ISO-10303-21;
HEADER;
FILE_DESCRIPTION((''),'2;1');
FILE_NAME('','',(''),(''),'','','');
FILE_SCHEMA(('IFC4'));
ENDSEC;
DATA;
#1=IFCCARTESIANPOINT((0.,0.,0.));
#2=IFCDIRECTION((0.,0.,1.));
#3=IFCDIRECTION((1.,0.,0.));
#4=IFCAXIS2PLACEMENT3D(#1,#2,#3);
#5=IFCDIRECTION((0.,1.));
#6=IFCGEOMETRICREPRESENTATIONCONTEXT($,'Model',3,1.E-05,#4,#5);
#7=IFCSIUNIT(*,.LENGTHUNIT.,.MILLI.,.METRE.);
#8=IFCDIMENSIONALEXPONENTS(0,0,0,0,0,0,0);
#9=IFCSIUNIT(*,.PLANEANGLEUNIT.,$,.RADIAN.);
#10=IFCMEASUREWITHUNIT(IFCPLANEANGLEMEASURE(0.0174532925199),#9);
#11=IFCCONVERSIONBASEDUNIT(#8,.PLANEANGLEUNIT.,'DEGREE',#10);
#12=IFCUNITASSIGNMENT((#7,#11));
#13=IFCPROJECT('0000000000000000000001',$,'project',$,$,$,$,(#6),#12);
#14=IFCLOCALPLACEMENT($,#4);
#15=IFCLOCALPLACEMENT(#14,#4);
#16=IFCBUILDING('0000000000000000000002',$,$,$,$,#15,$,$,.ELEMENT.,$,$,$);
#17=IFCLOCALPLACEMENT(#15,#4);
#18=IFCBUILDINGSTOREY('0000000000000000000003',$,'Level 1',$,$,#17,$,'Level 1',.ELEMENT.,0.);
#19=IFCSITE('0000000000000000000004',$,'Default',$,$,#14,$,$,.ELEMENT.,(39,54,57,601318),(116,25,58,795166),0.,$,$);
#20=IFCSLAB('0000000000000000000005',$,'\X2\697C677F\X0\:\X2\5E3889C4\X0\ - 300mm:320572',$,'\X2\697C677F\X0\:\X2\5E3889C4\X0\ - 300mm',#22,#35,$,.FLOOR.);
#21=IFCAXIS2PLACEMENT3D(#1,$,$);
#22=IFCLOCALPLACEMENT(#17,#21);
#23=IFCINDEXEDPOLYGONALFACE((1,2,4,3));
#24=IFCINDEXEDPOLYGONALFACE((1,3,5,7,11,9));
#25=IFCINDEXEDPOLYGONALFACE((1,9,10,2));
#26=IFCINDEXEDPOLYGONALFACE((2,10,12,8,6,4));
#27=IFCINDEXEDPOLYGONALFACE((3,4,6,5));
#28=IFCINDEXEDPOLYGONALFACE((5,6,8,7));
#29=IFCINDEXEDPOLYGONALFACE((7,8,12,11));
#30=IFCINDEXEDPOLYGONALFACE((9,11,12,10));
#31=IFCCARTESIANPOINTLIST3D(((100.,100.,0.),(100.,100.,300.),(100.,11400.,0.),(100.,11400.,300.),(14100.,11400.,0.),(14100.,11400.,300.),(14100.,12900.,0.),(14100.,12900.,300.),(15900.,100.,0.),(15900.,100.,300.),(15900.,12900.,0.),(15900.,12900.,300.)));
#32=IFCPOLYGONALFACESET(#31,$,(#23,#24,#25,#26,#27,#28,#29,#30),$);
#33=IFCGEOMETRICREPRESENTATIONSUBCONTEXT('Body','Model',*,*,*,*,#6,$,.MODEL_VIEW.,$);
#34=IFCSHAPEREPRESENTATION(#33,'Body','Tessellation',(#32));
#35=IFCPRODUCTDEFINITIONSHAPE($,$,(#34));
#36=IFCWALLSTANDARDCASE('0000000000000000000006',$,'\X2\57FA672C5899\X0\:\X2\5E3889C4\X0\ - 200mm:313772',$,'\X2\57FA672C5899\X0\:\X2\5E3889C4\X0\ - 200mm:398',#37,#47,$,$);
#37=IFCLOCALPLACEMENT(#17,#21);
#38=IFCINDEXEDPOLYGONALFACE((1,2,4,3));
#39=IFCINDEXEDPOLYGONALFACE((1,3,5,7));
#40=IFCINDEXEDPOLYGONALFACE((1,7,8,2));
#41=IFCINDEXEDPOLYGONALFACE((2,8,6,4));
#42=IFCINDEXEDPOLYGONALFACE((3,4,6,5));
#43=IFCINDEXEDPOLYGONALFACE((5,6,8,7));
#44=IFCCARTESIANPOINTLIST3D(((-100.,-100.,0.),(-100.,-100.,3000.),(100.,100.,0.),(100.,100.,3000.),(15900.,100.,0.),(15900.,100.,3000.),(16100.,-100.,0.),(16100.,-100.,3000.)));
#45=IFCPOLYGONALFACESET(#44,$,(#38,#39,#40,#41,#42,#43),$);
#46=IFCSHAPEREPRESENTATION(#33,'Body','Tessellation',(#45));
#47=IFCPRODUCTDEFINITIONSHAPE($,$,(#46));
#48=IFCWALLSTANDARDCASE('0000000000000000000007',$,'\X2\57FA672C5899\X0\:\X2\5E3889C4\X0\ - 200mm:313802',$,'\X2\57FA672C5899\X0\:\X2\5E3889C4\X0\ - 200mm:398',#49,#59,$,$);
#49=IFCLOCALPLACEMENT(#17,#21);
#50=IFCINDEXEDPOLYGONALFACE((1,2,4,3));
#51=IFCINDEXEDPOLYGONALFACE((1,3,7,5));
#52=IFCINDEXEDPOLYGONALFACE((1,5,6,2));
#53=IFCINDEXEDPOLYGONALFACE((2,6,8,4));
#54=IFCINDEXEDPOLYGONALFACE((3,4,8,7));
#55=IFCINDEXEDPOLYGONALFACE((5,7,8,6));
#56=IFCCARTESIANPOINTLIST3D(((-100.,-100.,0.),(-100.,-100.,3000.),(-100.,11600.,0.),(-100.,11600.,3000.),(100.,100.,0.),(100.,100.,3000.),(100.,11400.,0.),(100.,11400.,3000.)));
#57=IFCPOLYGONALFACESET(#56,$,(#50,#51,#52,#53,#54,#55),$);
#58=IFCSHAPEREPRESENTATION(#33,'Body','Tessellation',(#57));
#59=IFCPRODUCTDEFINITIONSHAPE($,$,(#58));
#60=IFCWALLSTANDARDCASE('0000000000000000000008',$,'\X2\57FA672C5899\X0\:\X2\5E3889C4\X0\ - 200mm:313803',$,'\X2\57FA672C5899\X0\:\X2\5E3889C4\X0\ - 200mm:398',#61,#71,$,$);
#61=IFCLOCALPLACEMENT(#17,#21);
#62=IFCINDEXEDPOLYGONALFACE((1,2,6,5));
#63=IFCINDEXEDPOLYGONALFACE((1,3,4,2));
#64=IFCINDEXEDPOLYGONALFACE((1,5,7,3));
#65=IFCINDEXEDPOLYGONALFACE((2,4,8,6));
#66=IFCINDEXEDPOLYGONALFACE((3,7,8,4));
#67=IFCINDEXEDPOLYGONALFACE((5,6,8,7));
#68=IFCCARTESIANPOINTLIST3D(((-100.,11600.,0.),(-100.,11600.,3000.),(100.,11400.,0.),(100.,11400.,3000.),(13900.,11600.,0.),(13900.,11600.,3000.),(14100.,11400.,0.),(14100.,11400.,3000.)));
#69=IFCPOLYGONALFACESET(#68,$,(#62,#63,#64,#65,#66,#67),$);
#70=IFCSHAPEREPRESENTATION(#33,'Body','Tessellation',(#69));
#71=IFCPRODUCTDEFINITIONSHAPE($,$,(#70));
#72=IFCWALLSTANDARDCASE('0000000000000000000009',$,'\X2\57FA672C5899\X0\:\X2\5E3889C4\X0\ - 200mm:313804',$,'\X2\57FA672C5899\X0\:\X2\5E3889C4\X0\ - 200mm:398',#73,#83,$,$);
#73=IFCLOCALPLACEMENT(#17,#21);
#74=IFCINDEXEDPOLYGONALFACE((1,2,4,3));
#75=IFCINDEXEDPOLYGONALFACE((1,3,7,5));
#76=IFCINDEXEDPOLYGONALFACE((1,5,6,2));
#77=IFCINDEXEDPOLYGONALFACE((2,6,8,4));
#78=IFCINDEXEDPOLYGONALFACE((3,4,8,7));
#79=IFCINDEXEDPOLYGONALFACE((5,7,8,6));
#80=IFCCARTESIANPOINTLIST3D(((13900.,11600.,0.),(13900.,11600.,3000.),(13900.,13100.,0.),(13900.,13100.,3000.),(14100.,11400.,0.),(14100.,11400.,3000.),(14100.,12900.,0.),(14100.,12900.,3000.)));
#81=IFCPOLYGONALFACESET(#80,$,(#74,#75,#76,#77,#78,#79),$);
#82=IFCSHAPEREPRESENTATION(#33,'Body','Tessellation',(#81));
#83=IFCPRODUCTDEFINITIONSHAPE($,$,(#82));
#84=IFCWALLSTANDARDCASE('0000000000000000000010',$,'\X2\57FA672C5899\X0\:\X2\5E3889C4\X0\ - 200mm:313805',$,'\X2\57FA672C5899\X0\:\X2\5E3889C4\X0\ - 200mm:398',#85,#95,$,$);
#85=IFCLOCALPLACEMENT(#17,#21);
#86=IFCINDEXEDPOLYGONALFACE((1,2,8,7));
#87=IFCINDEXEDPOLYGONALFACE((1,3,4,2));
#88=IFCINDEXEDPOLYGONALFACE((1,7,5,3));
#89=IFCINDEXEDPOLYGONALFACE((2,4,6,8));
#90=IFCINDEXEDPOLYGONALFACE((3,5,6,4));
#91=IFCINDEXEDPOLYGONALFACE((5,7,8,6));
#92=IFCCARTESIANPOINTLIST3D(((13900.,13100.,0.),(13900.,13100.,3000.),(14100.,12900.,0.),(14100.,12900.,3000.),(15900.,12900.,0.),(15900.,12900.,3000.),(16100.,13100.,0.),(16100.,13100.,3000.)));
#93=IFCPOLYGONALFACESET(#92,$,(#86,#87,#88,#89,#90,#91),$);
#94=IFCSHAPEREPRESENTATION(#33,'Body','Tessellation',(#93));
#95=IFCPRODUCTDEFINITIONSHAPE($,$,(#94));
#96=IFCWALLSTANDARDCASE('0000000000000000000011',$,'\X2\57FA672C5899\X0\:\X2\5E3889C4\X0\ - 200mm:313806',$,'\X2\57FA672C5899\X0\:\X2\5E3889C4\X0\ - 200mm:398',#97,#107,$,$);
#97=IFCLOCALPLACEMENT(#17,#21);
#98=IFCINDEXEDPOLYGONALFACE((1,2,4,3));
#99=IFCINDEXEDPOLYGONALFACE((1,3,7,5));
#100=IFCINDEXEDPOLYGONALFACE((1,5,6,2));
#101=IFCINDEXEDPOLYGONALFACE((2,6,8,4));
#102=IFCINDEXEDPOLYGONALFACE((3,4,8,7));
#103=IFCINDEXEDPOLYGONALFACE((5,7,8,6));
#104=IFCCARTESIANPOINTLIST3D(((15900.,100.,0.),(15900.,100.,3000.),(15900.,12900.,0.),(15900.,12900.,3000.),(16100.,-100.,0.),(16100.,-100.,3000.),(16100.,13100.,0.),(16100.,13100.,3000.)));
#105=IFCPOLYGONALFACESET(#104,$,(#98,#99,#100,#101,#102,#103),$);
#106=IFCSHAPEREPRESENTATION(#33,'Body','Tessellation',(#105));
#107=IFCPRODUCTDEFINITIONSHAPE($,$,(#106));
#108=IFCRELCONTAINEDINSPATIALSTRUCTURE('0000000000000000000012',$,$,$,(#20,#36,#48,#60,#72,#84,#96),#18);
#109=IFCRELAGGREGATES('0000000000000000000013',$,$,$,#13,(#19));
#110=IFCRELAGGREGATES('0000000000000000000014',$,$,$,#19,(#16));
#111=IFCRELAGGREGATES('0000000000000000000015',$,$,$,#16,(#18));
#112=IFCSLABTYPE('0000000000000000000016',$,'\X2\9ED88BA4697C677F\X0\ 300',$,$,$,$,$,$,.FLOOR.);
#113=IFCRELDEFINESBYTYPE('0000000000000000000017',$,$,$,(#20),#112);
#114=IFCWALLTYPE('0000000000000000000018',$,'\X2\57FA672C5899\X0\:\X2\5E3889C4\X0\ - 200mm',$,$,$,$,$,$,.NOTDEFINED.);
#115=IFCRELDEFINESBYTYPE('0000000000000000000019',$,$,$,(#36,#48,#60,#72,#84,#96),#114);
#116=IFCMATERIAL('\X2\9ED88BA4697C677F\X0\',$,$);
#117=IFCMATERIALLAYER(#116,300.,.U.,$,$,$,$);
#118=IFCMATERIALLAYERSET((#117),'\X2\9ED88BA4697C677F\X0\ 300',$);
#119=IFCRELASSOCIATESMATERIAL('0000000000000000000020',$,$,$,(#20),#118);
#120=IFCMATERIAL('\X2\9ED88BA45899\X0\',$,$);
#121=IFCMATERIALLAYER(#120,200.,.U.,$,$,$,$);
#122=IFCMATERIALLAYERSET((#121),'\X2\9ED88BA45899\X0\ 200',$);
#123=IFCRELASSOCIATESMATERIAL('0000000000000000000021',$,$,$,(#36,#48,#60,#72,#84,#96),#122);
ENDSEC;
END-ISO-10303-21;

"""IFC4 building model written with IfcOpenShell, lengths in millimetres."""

from ifc_helpers import new_model, entity, si_unit, converted_unit, direction, frame, origin_with_axes, place, context, subcontext, project, spatial, polyline, outline, extrude, material, layer, layer_set, layer_usage, type_object, element, save


model = new_model("IFC4")

# Units and contexts
model_context = context("Model", 3, precision=1e-05, world=origin_with_axes(), true_north=direction((0.0, 1.0)))
body_context = subcontext(model_context, "Body", "Model", "MODEL_VIEW")
ifc_project = project(units=[si_unit("LENGTHUNIT", "METRE", prefix="MILLI"), converted_unit("PLANEANGLEUNIT", "DEGREE", entity("IfcPlaneAngleMeasure", 0.0174532925199), si_unit("PLANEANGLEUNIT", "RADIAN"), dimensions=[0, 0, 0, 0, 0, 0, 0])], contexts=[model_context])

# Site, building, storey
site_placement = place(None, origin_with_axes())
site = spatial("IfcSite", under=ifc_project, at=site_placement, Name="Default", CompositionType="ELEMENT", RefLatitude=(39, 54, 57, 601318), RefLongitude=(116, 25, 58, 795166), RefElevation=0.0)
building_placement = place(site_placement, origin_with_axes())
building = spatial("IfcBuilding", under=site, at=building_placement, CompositionType="ELEMENT")
storey_placement = place(building_placement, origin_with_axes())
storey = spatial("IfcBuildingStorey", under=building, at=storey_placement, Name="Level 1", LongName="Level 1", CompositionType="ELEMENT", Elevation=0.0)

# Slab
ifc_material_1 = material(Name="默认楼板")
ifc_layer_1 = layer(ifc_material_1, 300.0, ventilated="UNKNOWN")
ifc_layer_set_1 = layer_set([ifc_layer_1], Name="默认楼板 300")
ifc_layer_usage_1 = layer_usage(ifc_layer_set_1, "AXIS3", "NEGATIVE", 300.0)
slab_type = type_object("IfcSlabType", Name="默认楼板 300", PredefinedType="FLOOR")
slab_placement = place(storey_placement, frame((100.0, 100.0, 0.0), z_axis=(0.0, 0.0, 1.0), x_axis=(1.0, 0.0, 0.0)))
element("IfcSlab", 1, at=slab_placement, inside=storey, type_object=slab_type, material=ifc_layer_usage_1, Name="楼板:常规 - 300mm:320572", ObjectType="楼板:常规 - 300mm", PredefinedType="FLOOR", context=body_context, shape_type="SweptSolid", body=[
    extrude(outline(polyline([(0.0, 0.0), (15800.0, 0.0), (15800.0, 12800.0), (14000.0, 12800.0), (14000.0, 11300.0), (0.0, 11300.0), (0.0, 0.0)])), origin_with_axes(), (0.0, 0.0, 1.0), 300.0),
])

# Walls
ifc_material_2 = material(Name="默认墙")
ifc_layer_2 = layer(ifc_material_2, 200.0, ventilated="UNKNOWN")
ifc_layer_set_2 = layer_set([ifc_layer_2], Name="默认墙 200")
ifc_layer_usage_2 = layer_usage(ifc_layer_set_2, "AXIS2", "POSITIVE", -100.0)
wall_type = type_object("IfcWallType", Name="基本墙:常规 - 200mm", PredefinedType="NOTDEFINED")
wall_1_placement = place(storey_placement, frame((16000.0, 0.0, 0.0), z_axis=(0.0, 0.0, 1.0), x_axis=(-1.0, 0.0, 0.0)))
element("IfcWallStandardCase", 2, at=wall_1_placement, inside=storey, type_object=wall_type, material=ifc_layer_usage_2, Name="基本墙:常规 - 200mm:313772", ObjectType="基本墙:常规 - 200mm:398", context=body_context, shape_type="SweptSolid", body=[
    extrude(outline(polyline([(100.0, -100.0), (15900.0, -100.0), (16100.0, 100.0), (-100.0, 100.0), (100.0, -100.0)])), origin_with_axes(), (0.0, 0.0, 1.0), 3000.0),
])
ifc_layer_usage_3 = layer_usage(ifc_layer_set_2, "AXIS2", "POSITIVE", -100.0)
wall_2_placement = place(storey_placement, frame((0.0, 0.0, 0.0), z_axis=(0.0, 0.0, 1.0), x_axis=(0.0, 1.0, 0.0)))
element("IfcWallStandardCase", 3, at=wall_2_placement, inside=storey, type_object=wall_type, material=ifc_layer_usage_3, Name="基本墙:常规 - 200mm:313802", ObjectType="基本墙:常规 - 200mm:398", context=body_context, shape_type="SweptSolid", body=[
    extrude(outline(polyline([(100.0, -100.0), (11400.0, -100.0), (11600.0, 100.0), (-100.0, 100.0), (100.0, -100.0)])), origin_with_axes(), (0.0, 0.0, 1.0), 3000.0),
])
ifc_layer_usage_4 = layer_usage(ifc_layer_set_2, "AXIS2", "POSITIVE", -100.0)
wall_3_placement = place(storey_placement, frame((0.0, 11500.0, 0.0), z_axis=(0.0, 0.0, 1.0), x_axis=(1.0, 0.0, 0.0)))
element("IfcWallStandardCase", 4, at=wall_3_placement, inside=storey, type_object=wall_type, material=ifc_layer_usage_4, Name="基本墙:常规 - 200mm:313803", ObjectType="基本墙:常规 - 200mm:398", context=body_context, shape_type="SweptSolid", body=[
    extrude(outline(polyline([(100.0, -100.0), (14100.0, -100.0), (13900.0, 100.0), (-100.0, 100.0), (100.0, -100.0)])), origin_with_axes(), (0.0, 0.0, 1.0), 3000.0),
])
ifc_layer_usage_5 = layer_usage(ifc_layer_set_2, "AXIS2", "POSITIVE", -100.0)
wall_4_placement = place(storey_placement, frame((14000.0, 11500.0, 0.0), z_axis=(0.0, 0.0, 1.0), x_axis=(0.0, 1.0, 0.0)))
element("IfcWallStandardCase", 5, at=wall_4_placement, inside=storey, type_object=wall_type, material=ifc_layer_usage_5, Name="基本墙:常规 - 200mm:313804", ObjectType="基本墙:常规 - 200mm:398", context=body_context, shape_type="SweptSolid", body=[
    extrude(outline(polyline([(-100.0, -100.0), (1400.0, -100.0), (1600.0, 100.0), (100.0, 100.0), (-100.0, -100.0)])), origin_with_axes(), (0.0, 0.0, 1.0), 3000.0),
])
ifc_layer_usage_6 = layer_usage(ifc_layer_set_2, "AXIS2", "POSITIVE", -100.0)
wall_5_placement = place(storey_placement, frame((14000.0, 13000.0, 0.0), z_axis=(0.0, 0.0, 1.0), x_axis=(1.0, 0.0, 0.0)))
element("IfcWallStandardCase", 6, at=wall_5_placement, inside=storey, type_object=wall_type, material=ifc_layer_usage_6, Name="基本墙:常规 - 200mm:313805", ObjectType="基本墙:常规 - 200mm:398", context=body_context, shape_type="SweptSolid", body=[
    extrude(outline(polyline([(100.0, -100.0), (1900.0, -100.0), (2100.0, 100.0), (-100.0, 100.0), (100.0, -100.0)])), origin_with_axes(), (0.0, 0.0, 1.0), 3000.0),
])
ifc_layer_usage_7 = layer_usage(ifc_layer_set_2, "AXIS2", "POSITIVE", -100.0)
wall_6_placement = place(storey_placement, frame((16000.0, 13000.0, 0.0), z_axis=(0.0, 0.0, 1.0), x_axis=(0.0, -1.0, 0.0)))
element("IfcWallStandardCase", 7, at=wall_6_placement, inside=storey, type_object=wall_type, material=ifc_layer_usage_7, Name="基本墙:常规 - 200mm:313806", ObjectType="基本墙:常规 - 200mm:398", context=body_context, shape_type="SweptSolid", body=[
    extrude(outline(polyline([(100.0, -100.0), (12900.0, -100.0), (13100.0, 100.0), (-100.0, 100.0), (100.0, -100.0)])), origin_with_axes(), (0.0, 0.0, 1.0), 3000.0),
])

save(model, "model.ifc")
